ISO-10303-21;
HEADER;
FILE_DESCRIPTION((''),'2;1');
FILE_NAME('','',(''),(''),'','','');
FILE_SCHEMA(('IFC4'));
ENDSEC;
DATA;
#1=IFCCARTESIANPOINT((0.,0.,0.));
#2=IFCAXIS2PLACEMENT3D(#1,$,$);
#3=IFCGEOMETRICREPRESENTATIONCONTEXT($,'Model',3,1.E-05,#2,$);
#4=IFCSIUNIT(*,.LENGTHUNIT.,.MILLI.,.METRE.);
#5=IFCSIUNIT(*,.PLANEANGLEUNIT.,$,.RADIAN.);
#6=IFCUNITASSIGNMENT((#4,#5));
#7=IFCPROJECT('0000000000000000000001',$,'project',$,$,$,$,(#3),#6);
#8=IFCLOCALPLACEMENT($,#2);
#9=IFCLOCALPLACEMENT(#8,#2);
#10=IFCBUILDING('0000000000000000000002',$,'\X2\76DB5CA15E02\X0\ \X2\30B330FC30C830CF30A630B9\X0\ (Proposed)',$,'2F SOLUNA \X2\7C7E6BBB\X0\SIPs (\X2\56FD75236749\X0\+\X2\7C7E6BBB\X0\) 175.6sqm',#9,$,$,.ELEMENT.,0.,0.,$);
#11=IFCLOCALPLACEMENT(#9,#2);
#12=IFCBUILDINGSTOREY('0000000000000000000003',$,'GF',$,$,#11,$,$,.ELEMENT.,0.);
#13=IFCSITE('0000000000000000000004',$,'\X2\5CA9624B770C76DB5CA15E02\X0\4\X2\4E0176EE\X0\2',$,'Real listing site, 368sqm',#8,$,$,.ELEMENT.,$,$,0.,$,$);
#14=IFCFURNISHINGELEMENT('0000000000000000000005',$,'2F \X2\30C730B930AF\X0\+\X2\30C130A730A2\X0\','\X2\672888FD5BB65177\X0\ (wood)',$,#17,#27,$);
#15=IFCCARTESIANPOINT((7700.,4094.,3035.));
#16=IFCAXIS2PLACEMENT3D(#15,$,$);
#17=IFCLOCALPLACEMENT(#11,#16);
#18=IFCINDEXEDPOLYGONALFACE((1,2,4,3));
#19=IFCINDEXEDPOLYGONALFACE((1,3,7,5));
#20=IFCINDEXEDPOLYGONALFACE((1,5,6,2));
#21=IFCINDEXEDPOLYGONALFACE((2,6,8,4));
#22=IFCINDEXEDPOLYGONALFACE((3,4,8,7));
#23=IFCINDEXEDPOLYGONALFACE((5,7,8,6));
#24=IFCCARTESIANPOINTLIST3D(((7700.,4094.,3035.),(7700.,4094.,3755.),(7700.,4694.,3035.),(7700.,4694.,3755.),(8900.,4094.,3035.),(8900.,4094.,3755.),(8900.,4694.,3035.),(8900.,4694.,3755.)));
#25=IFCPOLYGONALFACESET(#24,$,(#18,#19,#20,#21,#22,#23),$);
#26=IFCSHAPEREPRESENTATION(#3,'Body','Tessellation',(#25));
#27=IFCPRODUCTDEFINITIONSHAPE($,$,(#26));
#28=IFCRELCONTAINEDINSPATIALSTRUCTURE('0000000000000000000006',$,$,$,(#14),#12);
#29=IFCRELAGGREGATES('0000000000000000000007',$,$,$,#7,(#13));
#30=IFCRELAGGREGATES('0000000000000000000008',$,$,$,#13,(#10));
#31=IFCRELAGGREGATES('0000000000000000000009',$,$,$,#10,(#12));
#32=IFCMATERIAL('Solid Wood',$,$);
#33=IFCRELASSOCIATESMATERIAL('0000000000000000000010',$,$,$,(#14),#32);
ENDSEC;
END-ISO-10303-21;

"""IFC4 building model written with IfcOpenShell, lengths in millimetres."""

from ifc_helpers import new_model, si_unit, frame, frame_2d, origin, place, context, project, spatial, rectangle, extrude, material, element, save


model = new_model("IFC4")

# Units and contexts
model_context = context("Model", 3, precision=1e-05, world=origin())
ifc_project = project(units=[si_unit("LENGTHUNIT", "METRE", prefix="MILLI"), si_unit("PLANEANGLEUNIT", "RADIAN")], contexts=[model_context])

# Site, building, storey
site_placement = place(None, origin())
site = spatial("IfcSite", under=ifc_project, at=site_placement, Name="岩手県盛岡市4丁目2", ObjectType="Real listing site, 368sqm", CompositionType="ELEMENT", RefElevation=0.0)
building_placement = place(site_placement, origin())
building = spatial("IfcBuilding", under=site, at=building_placement, Name="盛岡市 コートハウス (Proposed)", ObjectType="2F SOLUNA 籾殻SIPs (国産杉+籾殻) 175.6sqm", CompositionType="ELEMENT", ElevationOfRefHeight=0.0, ElevationOfTerrain=0.0)
storey_placement = place(building_placement, origin())
storey = spatial("IfcBuildingStorey", under=building, at=storey_placement, Name="GF", CompositionType="ELEMENT", Elevation=0.0)

# Shared definitions
ifc_material_1 = material(Name="Solid Wood")

# Furnishing element
furnishing_1_placement = place(storey_placement, frame((7700.0, 4094.0, 3035.0)))
element("IfcFurnishingElement", 1, at=furnishing_1_placement, inside=storey, material=ifc_material_1, Name="2F デスク+チェア", Description="木製家具 (wood)", context=model_context, shape_type="SweptSolid", body=[
    extrude(rectangle(XDim=1200.0, YDim=600.0, at=frame_2d((600.0, 300.0))), frame((7700.0, 4094.0, 3035.0)), (0.0, 0.0, 1.0), 720.0),
])

save(model, "model.ifc")
